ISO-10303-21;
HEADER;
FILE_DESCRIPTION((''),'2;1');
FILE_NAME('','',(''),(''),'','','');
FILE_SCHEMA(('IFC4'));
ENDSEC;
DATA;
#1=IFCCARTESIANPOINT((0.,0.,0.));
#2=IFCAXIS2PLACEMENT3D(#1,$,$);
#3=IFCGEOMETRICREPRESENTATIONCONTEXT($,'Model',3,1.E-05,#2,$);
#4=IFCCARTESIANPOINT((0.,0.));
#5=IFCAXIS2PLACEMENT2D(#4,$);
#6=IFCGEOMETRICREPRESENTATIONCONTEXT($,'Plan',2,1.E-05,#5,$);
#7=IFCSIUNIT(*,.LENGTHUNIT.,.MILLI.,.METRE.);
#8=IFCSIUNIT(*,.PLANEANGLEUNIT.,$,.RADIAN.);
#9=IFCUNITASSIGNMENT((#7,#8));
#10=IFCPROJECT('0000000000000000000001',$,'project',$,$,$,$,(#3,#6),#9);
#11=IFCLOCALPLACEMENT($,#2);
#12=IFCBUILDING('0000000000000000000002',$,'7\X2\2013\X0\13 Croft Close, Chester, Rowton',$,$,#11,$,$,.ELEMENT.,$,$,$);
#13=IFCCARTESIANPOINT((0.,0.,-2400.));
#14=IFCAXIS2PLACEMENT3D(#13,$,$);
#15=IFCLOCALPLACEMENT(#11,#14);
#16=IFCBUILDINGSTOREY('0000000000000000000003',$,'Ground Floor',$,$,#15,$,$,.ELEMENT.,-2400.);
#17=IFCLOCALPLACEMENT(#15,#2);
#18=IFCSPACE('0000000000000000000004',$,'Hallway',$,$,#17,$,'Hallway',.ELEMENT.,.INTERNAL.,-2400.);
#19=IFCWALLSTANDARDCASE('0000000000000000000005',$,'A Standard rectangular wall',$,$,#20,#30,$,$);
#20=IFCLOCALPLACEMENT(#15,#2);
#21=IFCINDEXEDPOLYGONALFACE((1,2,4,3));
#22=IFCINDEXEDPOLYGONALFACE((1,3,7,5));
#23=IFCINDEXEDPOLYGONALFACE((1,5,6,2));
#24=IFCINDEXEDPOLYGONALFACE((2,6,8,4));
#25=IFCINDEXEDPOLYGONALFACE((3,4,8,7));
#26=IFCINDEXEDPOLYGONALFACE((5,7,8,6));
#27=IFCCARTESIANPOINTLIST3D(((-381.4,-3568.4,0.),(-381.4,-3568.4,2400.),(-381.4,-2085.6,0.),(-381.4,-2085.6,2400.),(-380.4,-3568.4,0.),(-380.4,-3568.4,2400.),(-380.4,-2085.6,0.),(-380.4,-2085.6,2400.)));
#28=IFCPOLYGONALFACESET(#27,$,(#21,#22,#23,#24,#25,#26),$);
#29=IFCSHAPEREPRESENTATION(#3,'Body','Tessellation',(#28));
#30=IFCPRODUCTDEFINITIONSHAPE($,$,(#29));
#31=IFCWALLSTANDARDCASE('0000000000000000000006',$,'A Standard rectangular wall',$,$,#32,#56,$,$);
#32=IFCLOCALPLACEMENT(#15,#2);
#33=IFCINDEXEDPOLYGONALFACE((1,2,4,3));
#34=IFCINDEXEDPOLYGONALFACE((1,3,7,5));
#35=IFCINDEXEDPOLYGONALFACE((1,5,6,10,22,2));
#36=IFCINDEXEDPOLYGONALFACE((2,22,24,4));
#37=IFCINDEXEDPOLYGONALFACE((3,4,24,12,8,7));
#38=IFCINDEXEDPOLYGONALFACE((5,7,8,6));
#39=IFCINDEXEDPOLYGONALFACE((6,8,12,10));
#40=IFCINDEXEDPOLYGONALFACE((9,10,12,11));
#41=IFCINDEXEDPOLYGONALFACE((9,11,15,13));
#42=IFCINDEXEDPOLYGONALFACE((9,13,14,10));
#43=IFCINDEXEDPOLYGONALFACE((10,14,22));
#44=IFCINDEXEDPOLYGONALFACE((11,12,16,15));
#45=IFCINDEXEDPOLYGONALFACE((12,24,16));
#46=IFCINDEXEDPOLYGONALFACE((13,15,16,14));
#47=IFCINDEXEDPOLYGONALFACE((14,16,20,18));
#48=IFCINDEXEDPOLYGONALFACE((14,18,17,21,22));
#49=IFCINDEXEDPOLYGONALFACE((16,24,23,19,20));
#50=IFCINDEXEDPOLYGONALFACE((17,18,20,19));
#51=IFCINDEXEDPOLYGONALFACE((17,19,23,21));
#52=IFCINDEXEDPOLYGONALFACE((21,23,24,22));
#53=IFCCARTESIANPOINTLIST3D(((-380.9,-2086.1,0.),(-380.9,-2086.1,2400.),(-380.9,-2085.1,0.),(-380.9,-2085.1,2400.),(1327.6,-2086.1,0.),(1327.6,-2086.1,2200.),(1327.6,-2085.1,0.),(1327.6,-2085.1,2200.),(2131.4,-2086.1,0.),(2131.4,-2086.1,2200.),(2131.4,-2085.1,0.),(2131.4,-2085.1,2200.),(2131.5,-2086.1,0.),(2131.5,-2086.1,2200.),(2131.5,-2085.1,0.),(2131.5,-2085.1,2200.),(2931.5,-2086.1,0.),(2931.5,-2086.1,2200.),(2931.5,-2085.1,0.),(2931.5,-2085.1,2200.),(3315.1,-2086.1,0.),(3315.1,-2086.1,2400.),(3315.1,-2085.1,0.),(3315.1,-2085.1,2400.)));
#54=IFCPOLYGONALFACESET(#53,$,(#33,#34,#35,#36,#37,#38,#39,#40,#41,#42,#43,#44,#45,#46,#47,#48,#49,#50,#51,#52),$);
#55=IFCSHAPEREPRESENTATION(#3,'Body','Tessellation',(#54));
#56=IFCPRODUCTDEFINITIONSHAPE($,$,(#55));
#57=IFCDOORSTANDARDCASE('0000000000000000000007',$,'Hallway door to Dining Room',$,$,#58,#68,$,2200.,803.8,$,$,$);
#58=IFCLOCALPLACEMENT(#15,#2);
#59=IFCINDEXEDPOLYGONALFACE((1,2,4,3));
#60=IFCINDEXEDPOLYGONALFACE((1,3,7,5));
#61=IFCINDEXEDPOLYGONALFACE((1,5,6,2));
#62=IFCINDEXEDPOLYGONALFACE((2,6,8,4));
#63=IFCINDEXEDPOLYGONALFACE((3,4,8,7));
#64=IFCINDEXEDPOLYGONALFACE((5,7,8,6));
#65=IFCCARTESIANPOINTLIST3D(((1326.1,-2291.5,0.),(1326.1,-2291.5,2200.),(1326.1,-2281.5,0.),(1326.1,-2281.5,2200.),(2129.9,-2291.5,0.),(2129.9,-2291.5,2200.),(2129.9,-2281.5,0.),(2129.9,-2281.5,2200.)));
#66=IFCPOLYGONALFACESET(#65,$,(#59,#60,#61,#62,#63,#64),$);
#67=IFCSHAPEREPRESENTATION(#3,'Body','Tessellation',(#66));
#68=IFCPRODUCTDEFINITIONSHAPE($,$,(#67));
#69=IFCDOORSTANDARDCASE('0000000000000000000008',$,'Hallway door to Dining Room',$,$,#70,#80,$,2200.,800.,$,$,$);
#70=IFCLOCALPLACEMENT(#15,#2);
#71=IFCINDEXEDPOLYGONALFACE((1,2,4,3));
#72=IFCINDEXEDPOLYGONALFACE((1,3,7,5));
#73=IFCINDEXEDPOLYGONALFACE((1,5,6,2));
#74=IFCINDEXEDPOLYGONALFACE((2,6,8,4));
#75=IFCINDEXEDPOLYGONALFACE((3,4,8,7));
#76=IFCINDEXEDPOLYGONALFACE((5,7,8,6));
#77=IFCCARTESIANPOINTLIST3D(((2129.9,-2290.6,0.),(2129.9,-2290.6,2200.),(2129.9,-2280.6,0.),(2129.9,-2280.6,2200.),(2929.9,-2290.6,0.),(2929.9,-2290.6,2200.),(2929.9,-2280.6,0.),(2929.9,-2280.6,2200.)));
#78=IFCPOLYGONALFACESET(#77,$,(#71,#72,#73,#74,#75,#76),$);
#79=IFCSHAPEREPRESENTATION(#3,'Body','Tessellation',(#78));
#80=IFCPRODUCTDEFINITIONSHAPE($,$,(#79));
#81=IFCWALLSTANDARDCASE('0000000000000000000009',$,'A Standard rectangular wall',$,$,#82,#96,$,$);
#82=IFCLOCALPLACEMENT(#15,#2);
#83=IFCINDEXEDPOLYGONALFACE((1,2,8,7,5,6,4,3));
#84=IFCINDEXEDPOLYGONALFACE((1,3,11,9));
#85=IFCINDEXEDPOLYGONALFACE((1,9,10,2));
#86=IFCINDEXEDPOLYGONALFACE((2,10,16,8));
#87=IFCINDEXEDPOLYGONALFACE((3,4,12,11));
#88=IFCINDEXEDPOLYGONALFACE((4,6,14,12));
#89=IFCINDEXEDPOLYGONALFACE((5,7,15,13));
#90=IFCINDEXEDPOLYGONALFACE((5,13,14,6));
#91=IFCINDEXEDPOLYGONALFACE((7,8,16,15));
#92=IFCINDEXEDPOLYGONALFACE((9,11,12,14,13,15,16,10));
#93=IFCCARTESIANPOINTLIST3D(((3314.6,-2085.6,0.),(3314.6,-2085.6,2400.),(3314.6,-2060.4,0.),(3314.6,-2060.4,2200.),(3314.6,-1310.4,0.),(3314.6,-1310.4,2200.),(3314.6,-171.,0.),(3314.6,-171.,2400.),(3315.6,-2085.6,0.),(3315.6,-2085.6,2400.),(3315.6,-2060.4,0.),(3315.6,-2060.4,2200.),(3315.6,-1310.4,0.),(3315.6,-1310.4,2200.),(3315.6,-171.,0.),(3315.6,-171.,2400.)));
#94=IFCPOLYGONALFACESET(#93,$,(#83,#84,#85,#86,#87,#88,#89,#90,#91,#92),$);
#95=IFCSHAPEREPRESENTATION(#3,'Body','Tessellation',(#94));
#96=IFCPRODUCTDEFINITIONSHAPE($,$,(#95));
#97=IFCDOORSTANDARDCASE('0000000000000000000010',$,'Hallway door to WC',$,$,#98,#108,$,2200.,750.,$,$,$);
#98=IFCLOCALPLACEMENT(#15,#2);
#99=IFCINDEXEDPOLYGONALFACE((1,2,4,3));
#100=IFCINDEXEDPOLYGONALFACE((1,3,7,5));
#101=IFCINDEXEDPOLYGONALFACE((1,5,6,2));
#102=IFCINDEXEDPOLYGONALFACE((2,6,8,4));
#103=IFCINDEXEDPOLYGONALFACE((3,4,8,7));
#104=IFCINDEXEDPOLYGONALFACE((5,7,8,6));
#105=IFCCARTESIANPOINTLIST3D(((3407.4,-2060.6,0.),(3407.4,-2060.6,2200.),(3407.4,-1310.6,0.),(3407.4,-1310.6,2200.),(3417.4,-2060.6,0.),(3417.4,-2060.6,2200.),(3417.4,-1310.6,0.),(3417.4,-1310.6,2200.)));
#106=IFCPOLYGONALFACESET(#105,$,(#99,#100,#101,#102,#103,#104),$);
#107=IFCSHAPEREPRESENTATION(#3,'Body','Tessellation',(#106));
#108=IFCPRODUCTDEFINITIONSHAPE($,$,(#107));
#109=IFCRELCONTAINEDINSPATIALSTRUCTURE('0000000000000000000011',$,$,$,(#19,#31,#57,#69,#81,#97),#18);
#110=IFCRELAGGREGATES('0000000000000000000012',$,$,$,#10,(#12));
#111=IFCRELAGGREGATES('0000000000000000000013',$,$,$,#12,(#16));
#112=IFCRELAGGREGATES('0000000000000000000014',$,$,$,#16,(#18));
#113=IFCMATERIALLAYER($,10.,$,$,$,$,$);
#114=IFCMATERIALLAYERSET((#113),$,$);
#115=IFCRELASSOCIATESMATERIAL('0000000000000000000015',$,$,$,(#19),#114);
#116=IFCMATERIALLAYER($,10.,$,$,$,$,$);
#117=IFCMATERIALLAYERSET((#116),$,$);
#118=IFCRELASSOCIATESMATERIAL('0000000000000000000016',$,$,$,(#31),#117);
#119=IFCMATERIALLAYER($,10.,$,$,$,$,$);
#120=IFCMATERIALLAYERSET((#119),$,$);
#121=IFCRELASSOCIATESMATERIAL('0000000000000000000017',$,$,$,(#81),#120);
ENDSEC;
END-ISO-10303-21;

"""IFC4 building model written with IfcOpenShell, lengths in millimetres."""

from ifc_helpers import new_model, si_unit, frame, origin, origin_2d, place, context, project, spatial, rectangle, extrude, layer, layer_set, layer_usage, element, fill, save


model = new_model("IFC4")

# Units and contexts
model_context = context("Model", 3, precision=1e-05, world=origin())
plan_context = context("Plan", 2, precision=1e-05, world=origin_2d())
ifc_project = project(units=[si_unit("LENGTHUNIT", "METRE", prefix="MILLI"), si_unit("PLANEANGLEUNIT", "RADIAN")], contexts=[model_context, plan_context])

# Building, storey
building_placement = place(None, origin())
building = spatial("IfcBuilding", under=ifc_project, at=building_placement, Name="7–13 Croft Close, Chester, Rowton", CompositionType="ELEMENT")
storey_placement = place(building_placement, frame((0.0, 0.0, -2400.0)))
storey = spatial("IfcBuildingStorey", under=building, at=storey_placement, Name="Ground Floor", CompositionType="ELEMENT", Elevation=-2400.0)

# Shared definitions
space_1_placement = place(storey_placement, origin())
space_1 = spatial("IfcSpace", under=storey, at=space_1_placement, Name="Hallway", LongName="Hallway", CompositionType="ELEMENT", PredefinedType="INTERNAL", ElevationWithFlooring=-2400.0)

# Wall
ifc_layer_1 = layer(None, 10.0)
ifc_layer_set_1 = layer_set([ifc_layer_1])
ifc_layer_usage_1 = layer_usage(ifc_layer_set_1, "AXIS2", "NEGATIVE", 150.0)
wall_1_placement = place(storey_placement, origin())
element("IfcWallStandardCase", 1, at=wall_1_placement, inside=space_1, material=ifc_layer_usage_1, Name="A Standard rectangular wall", context=model_context, shape_type="SweptSolid", body=[
    extrude(rectangle(XDim=1.0, YDim=1482.8, at=origin_2d()), frame((-380.9, -2827.0, 0.0), x_axis=(-1.0, 0.0, 0.0)), (0.0, 0.0, 1.0), 2400.0),
])

# Wall, openings, doors
ifc_layer_2 = layer(None, 10.0)
ifc_layer_set_2 = layer_set([ifc_layer_2])
ifc_layer_usage_2 = layer_usage(ifc_layer_set_2, "AXIS2", "NEGATIVE", 150.0)
wall_2_placement = place(storey_placement, origin())
wall_2 = element("IfcWallStandardCase", 2, at=wall_2_placement, inside=space_1, material=ifc_layer_usage_2, Name="A Standard rectangular wall", context=model_context, shape_type="SweptSolid", body=[
    extrude(rectangle(XDim=1.0, YDim=3696.0, at=origin_2d()), frame((1467.1, -2085.6, 0.0), x_axis=(0.0, 1.0, 0.0)), (0.0, 0.0, 1.0), 2400.0),
])
opening_1_placement = place(storey_placement, origin())
opening_1 = element("IfcOpeningElement", 3, at=opening_1_placement, cuts=wall_2, context=model_context, shape_type="SweptSolid", body=[
    extrude(rectangle(XDim=10.0, YDim=803.8, at=origin_2d()), frame((1729.5, -2085.6, 0.0), x_axis=(0.0, 1.0, 0.0)), (0.0, 0.0, 1.0), 2200.0),
])
opening_2_placement = place(storey_placement, origin())
opening_2 = element("IfcOpeningElement", 4, at=opening_2_placement, cuts=wall_2, context=model_context, shape_type="SweptSolid", body=[
    extrude(rectangle(XDim=10.0, YDim=800.0, at=origin_2d()), frame((2531.5, -2085.6, 0.0), x_axis=(0.0, 1.0, 0.0)), (0.0, 0.0, 1.0), 2200.0),
])
door_1_placement = place(storey_placement, frame((-1.5, -200.9, 0.0)))
door_1 = element("IfcDoorStandardCase", 5, at=door_1_placement, inside=space_1, Name="Hallway door to Dining Room", OverallHeight=2200.0, OverallWidth=803.8, context=model_context, shape_type="SweptSolid", body=[
    extrude(rectangle(XDim=10.0, YDim=803.8, at=origin_2d()), frame((1729.5, -2085.6, 0.0), x_axis=(0.0, 1.0, 0.0)), (0.0, 0.0, 1.0), 2200.0),
])
fill(opening_1, door_1)
door_2_placement = place(storey_placement, frame((-1.6, -200.0, 0.0)))
door_2 = element("IfcDoorStandardCase", 6, at=door_2_placement, inside=space_1, Name="Hallway door to Dining Room", OverallHeight=2200.0, OverallWidth=800.0, context=model_context, shape_type="SweptSolid", body=[
    extrude(rectangle(XDim=10.0, YDim=800.0, at=origin_2d()), frame((2531.5, -2085.6, 0.0), x_axis=(0.0, 1.0, 0.0)), (0.0, 0.0, 1.0), 2200.0),
])
fill(opening_2, door_2)

# Wall, opening, door
ifc_layer_3 = layer(None, 10.0)
ifc_layer_set_3 = layer_set([ifc_layer_3])
ifc_layer_usage_3 = layer_usage(ifc_layer_set_3, "AXIS2", "NEGATIVE", 150.0)
wall_3_placement = place(storey_placement, origin())
wall_3 = element("IfcWallStandardCase", 7, at=wall_3_placement, inside=space_1, material=ifc_layer_usage_3, Name="A Standard rectangular wall", context=model_context, shape_type="SweptSolid", body=[
    extrude(rectangle(XDim=1.0, YDim=1914.6, at=origin_2d()), frame((3315.1, -1128.3, 0.0), x_axis=(-1.0, 0.0, 0.0)), (0.0, 0.0, 1.0), 2400.0),
])
opening_3_placement = place(storey_placement, origin())
opening_3 = element("IfcOpeningElement", 8, at=opening_3_placement, cuts=wall_3, context=model_context, shape_type="SweptSolid", body=[
    extrude(rectangle(XDim=10.0, YDim=750.0, at=origin_2d()), frame((3315.1, -1685.4, 0.0), x_axis=(-1.0, 0.0, 0.0)), (0.0, 0.0, 1.0), 2200.0),
])
door_3_placement = place(storey_placement, frame((97.3, -0.2, 0.0)))
door_3 = element("IfcDoorStandardCase", 9, at=door_3_placement, inside=space_1, Name="Hallway door to WC", OverallHeight=2200.0, OverallWidth=750.0, context=model_context, shape_type="SweptSolid", body=[
    extrude(rectangle(XDim=10.0, YDim=750.0, at=origin_2d()), frame((3315.1, -1685.4, 0.0), x_axis=(-1.0, 0.0, 0.0)), (0.0, 0.0, 1.0), 2200.0),
])
fill(opening_3, door_3)

save(model, "model.ifc")
